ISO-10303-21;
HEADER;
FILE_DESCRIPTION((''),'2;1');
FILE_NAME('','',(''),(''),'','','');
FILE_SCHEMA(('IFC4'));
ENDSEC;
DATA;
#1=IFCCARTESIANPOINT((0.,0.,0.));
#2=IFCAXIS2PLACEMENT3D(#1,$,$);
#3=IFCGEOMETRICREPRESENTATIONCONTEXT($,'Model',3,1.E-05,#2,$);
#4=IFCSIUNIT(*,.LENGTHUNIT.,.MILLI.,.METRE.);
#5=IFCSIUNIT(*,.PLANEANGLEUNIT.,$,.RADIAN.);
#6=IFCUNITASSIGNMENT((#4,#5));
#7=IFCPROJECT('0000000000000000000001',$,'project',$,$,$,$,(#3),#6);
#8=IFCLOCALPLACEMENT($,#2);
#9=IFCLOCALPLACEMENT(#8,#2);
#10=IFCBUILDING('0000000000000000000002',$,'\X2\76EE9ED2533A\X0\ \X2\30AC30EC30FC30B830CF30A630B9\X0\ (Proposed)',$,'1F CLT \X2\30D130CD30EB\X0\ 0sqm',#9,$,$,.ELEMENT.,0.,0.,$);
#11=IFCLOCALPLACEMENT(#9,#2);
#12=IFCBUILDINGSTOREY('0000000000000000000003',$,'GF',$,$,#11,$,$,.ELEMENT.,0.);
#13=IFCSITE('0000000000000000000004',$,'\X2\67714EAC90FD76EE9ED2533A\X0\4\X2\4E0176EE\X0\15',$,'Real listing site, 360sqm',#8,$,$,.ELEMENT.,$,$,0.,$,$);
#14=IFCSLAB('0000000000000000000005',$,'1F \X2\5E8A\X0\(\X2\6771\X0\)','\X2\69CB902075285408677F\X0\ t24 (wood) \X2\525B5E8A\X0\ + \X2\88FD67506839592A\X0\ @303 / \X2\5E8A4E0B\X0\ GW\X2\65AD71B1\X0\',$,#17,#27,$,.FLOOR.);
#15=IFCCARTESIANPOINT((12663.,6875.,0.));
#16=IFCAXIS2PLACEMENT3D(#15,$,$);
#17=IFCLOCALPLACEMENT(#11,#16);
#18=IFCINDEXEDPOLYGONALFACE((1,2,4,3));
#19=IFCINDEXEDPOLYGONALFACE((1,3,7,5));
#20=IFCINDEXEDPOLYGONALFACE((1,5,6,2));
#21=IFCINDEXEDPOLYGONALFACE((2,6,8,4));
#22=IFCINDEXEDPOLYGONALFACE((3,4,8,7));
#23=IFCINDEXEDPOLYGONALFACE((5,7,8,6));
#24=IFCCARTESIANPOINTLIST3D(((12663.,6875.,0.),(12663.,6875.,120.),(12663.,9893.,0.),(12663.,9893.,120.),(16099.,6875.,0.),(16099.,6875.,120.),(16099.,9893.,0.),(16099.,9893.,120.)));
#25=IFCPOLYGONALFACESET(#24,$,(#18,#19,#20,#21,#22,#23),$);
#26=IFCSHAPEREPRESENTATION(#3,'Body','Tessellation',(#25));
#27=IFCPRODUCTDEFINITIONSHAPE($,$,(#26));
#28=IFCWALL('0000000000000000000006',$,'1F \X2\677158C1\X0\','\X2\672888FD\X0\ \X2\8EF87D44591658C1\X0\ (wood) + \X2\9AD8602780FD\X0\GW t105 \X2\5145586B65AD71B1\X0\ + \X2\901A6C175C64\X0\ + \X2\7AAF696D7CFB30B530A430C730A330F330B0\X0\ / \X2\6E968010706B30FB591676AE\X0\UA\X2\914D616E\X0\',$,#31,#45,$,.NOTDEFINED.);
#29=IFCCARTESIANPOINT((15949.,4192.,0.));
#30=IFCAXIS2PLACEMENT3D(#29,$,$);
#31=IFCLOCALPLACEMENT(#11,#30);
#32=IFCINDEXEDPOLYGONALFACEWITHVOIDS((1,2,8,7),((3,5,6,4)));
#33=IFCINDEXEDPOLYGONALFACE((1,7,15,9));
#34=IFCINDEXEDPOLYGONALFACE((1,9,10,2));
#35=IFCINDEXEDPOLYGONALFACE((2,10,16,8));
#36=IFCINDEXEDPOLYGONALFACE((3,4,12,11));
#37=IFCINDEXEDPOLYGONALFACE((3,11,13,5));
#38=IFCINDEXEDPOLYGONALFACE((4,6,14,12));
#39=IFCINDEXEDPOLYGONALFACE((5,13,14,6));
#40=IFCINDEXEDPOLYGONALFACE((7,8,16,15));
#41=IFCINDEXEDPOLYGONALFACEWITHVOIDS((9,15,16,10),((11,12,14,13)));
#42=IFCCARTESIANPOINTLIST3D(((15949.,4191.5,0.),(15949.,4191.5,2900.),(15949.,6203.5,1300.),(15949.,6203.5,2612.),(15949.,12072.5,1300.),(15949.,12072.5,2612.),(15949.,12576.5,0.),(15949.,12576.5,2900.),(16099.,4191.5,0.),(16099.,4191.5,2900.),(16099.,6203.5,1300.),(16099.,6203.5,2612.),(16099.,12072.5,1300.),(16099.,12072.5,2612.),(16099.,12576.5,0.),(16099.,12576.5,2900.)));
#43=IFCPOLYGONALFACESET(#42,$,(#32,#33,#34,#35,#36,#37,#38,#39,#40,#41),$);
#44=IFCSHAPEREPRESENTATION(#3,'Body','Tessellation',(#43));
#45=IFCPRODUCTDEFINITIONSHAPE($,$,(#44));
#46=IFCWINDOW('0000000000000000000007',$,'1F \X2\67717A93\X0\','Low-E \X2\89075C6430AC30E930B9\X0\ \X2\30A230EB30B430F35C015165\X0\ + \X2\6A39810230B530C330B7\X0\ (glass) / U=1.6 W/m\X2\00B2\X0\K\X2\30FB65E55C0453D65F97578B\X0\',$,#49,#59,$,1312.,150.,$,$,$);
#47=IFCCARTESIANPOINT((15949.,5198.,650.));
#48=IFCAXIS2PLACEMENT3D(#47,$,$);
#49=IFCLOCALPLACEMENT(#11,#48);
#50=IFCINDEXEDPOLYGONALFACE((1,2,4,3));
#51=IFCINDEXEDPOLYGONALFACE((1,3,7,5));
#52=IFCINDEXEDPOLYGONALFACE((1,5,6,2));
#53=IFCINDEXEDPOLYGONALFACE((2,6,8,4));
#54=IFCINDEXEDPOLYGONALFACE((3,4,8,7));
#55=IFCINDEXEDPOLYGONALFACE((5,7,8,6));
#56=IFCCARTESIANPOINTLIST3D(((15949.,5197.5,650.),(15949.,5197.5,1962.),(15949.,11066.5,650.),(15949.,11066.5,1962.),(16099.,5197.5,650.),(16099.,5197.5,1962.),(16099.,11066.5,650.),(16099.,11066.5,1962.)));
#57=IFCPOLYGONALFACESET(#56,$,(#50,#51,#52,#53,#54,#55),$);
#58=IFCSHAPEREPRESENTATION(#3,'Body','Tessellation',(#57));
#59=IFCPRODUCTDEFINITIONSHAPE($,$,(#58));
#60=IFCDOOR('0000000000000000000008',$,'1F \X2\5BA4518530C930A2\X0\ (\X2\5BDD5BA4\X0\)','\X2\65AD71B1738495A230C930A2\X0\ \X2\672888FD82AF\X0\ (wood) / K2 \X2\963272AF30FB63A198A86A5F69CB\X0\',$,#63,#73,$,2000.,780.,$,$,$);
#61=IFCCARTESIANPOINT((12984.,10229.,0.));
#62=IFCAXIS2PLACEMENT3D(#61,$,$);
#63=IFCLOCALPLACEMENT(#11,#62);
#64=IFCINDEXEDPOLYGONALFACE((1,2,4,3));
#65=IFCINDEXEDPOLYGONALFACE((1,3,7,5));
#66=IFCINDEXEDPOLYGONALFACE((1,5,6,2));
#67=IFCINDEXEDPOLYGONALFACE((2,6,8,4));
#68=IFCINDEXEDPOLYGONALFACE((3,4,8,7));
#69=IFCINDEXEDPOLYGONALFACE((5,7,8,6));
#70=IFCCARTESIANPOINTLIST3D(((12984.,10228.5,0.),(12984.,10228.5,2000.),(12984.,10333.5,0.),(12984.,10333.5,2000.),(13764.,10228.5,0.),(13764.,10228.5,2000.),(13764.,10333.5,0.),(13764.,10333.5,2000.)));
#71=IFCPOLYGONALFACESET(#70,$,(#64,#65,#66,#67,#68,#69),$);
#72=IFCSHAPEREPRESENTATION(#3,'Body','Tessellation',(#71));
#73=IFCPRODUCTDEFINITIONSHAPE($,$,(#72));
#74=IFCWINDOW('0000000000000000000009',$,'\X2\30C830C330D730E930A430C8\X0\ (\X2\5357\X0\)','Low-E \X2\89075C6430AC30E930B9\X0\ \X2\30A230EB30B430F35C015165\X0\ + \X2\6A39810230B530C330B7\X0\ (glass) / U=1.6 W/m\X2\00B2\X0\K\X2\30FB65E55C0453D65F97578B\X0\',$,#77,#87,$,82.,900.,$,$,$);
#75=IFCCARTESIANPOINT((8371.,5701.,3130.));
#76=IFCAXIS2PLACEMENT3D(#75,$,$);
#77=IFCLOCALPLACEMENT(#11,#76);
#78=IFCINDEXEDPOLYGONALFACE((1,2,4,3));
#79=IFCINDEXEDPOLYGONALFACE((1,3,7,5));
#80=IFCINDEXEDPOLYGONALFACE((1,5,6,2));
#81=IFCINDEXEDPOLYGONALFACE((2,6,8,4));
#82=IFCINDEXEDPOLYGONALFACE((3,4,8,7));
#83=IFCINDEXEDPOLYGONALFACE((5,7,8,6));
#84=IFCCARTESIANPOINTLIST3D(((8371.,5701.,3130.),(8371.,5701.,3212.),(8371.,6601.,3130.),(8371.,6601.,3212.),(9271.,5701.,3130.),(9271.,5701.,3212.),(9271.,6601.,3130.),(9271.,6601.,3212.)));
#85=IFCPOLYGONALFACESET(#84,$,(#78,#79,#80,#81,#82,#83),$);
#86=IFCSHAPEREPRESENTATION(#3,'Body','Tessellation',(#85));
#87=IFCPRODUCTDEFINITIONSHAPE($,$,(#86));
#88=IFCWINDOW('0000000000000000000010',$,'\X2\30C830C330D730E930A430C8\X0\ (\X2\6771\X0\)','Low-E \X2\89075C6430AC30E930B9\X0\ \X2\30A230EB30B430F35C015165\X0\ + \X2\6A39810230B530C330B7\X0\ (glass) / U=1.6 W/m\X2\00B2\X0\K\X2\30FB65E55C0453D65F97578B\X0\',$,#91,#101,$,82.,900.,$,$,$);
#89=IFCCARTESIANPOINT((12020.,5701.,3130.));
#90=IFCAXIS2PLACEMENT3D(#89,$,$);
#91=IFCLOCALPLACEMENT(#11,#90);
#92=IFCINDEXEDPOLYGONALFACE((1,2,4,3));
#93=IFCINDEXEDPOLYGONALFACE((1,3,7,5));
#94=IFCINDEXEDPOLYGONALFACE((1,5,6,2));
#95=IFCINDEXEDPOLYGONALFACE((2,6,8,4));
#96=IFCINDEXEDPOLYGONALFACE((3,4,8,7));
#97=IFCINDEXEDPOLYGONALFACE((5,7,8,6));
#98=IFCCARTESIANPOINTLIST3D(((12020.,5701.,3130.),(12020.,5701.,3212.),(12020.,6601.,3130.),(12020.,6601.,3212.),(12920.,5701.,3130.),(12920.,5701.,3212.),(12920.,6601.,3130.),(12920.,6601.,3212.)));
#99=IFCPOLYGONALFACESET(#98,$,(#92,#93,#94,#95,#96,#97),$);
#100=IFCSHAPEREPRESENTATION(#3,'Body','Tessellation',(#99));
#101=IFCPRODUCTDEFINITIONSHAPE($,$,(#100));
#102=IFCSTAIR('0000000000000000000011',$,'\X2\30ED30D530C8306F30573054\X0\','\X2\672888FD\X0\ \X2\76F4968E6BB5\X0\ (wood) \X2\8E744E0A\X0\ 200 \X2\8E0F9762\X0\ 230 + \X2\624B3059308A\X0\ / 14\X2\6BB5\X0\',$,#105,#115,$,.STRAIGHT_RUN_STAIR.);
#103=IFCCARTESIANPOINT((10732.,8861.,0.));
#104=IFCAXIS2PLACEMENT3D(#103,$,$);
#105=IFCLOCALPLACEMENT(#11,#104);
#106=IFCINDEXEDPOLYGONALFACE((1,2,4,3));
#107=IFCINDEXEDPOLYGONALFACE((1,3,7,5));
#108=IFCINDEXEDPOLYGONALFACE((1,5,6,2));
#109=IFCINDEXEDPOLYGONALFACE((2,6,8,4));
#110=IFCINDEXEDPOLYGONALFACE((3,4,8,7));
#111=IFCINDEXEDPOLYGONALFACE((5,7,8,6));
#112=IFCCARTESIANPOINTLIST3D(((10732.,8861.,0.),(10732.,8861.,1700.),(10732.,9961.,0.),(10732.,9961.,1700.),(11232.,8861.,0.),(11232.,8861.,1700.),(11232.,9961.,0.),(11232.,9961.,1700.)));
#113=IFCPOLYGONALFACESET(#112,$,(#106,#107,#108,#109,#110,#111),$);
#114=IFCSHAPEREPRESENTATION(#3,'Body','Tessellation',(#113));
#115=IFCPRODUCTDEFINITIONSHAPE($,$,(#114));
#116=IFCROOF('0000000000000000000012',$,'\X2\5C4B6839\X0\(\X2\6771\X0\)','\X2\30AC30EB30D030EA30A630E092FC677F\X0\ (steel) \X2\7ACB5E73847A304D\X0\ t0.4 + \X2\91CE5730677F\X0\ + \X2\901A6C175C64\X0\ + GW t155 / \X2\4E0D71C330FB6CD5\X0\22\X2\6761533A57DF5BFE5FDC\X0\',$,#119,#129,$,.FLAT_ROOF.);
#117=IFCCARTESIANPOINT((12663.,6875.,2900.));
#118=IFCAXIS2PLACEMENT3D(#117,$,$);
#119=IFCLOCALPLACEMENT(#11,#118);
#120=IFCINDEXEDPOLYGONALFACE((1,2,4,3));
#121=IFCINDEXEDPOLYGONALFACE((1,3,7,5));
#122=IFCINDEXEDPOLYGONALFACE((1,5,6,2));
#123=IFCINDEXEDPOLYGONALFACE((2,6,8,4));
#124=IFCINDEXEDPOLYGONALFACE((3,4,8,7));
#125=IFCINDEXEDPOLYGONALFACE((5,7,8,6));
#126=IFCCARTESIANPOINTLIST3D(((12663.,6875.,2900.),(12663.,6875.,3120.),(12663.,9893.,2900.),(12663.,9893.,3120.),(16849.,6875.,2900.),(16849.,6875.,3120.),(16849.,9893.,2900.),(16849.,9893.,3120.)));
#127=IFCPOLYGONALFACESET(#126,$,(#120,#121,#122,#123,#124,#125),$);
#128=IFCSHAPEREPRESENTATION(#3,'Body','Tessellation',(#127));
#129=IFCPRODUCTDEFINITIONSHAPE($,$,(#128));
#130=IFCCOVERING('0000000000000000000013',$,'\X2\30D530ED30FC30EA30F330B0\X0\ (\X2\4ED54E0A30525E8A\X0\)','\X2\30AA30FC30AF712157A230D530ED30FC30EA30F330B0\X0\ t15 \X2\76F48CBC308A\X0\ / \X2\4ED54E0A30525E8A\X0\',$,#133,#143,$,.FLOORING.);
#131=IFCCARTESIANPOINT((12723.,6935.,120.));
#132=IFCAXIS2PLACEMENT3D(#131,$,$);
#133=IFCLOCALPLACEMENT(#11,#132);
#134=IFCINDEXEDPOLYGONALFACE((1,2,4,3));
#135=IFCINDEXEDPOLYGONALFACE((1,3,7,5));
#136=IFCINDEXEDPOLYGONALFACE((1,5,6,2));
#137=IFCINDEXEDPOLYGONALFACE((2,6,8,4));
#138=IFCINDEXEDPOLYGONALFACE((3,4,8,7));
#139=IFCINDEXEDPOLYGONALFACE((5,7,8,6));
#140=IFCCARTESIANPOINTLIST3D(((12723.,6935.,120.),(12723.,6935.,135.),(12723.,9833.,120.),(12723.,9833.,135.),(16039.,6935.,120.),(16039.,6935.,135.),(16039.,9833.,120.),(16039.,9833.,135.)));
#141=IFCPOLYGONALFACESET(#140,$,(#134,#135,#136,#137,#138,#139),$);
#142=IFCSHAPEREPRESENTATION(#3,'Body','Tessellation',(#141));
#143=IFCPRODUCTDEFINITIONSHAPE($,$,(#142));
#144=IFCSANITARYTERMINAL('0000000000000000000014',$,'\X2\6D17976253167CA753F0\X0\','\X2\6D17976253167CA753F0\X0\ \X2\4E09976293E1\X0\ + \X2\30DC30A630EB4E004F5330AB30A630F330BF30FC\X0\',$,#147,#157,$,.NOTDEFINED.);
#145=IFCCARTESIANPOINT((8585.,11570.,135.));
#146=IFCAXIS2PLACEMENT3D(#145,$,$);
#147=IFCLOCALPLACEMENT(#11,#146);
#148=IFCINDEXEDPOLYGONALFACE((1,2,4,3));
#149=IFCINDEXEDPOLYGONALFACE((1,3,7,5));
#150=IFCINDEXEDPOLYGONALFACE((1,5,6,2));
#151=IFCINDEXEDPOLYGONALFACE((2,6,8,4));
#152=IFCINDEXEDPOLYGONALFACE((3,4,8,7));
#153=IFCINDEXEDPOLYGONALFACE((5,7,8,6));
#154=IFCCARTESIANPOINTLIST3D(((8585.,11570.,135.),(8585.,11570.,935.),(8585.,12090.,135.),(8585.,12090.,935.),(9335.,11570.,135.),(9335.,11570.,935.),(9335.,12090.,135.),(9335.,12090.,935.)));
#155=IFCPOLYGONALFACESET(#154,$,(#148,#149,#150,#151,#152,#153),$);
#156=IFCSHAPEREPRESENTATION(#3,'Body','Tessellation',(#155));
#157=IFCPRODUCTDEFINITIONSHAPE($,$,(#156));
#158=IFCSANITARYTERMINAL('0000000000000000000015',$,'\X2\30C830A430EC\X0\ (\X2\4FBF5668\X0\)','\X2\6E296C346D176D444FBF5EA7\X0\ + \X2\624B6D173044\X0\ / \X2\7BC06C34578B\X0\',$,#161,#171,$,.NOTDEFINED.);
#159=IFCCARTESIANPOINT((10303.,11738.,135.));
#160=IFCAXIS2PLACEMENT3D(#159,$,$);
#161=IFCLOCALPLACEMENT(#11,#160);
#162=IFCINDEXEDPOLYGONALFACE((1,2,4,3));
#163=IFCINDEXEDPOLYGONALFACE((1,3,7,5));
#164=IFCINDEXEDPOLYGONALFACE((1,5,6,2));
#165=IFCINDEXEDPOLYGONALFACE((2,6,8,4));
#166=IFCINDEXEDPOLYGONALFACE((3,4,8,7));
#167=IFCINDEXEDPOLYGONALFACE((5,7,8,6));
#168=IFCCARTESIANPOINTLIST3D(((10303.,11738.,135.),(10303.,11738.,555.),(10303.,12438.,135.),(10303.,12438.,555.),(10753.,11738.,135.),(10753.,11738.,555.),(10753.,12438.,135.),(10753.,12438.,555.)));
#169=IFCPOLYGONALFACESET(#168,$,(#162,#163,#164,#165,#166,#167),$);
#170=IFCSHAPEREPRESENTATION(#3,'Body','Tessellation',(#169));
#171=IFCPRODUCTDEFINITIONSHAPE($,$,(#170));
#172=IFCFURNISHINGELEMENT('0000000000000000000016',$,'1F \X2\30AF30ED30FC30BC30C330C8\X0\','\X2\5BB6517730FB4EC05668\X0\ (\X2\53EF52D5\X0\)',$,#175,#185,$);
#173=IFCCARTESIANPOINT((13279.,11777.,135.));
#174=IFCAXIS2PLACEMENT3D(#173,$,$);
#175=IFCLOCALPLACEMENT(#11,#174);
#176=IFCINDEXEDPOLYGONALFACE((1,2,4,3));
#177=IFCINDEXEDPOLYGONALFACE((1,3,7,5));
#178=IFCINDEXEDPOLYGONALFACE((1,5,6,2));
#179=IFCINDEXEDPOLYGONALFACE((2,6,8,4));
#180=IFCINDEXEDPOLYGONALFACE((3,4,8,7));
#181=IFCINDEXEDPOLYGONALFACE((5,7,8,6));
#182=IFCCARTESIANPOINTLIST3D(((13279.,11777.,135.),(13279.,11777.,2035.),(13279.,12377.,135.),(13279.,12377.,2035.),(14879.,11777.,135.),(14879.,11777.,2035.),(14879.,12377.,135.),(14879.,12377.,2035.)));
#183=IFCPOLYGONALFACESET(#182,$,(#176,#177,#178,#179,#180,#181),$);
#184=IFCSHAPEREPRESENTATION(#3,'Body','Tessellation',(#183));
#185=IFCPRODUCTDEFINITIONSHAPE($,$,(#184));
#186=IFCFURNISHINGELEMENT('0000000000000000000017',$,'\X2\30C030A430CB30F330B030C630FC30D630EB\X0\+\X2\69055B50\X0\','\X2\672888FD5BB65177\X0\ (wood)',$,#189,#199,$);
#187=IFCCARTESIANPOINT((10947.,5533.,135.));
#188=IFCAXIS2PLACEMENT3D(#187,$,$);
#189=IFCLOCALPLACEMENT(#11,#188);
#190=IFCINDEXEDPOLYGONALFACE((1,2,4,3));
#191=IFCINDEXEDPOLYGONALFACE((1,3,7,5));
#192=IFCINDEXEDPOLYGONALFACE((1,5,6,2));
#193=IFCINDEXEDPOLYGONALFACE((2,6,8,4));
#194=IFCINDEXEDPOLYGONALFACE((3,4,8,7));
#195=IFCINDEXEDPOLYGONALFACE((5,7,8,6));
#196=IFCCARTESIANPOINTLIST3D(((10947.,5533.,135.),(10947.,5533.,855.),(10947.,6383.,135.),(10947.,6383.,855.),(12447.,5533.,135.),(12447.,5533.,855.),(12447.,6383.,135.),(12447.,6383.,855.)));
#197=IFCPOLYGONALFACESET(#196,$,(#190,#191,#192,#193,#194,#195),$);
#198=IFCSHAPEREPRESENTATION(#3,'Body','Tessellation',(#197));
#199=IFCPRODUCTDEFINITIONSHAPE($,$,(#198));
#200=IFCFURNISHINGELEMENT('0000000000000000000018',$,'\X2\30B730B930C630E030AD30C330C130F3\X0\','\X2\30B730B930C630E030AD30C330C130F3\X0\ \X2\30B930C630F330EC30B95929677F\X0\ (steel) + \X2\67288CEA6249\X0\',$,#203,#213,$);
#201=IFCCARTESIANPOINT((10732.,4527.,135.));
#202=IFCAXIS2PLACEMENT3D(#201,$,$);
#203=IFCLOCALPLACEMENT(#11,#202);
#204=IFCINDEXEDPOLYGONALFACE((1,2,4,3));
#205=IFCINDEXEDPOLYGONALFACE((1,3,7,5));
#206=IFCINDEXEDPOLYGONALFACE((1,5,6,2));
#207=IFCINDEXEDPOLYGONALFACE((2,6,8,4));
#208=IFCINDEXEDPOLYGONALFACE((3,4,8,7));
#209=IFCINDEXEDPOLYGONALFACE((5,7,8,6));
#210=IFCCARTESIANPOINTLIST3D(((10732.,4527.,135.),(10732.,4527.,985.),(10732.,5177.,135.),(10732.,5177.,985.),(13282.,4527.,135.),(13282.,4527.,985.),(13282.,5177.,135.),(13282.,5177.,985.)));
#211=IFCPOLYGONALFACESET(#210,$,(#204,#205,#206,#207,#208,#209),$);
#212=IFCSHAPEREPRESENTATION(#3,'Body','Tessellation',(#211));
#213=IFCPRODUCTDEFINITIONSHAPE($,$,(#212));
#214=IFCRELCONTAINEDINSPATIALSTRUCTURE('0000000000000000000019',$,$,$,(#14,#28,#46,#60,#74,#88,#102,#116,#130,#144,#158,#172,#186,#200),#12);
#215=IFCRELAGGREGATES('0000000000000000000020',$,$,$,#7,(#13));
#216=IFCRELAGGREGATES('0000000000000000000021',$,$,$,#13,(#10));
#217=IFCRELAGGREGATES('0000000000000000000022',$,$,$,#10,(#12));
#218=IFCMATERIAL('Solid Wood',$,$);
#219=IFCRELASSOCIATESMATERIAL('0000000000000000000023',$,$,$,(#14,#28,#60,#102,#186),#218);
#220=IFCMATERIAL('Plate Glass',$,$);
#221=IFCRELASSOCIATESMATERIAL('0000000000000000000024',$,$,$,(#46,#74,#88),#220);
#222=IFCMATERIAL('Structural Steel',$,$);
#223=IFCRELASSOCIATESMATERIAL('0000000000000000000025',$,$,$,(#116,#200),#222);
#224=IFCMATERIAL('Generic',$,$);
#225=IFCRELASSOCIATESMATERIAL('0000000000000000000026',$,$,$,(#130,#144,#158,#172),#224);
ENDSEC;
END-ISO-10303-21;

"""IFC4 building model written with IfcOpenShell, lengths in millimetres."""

from ifc_helpers import new_model, si_unit, frame, frame_2d, origin, place, context, project, spatial, rectangle, extrude, material, element, fill, save


model = new_model("IFC4")

# Units and contexts
model_context = context("Model", 3, precision=1e-05, world=origin())
ifc_project = project(units=[si_unit("LENGTHUNIT", "METRE", prefix="MILLI"), si_unit("PLANEANGLEUNIT", "RADIAN")], contexts=[model_context])

# Site, building, storey
site_placement = place(None, origin())
site = spatial("IfcSite", under=ifc_project, at=site_placement, Name="東京都目黒区4丁目15", ObjectType="Real listing site, 360sqm", CompositionType="ELEMENT", RefElevation=0.0)
building_placement = place(site_placement, origin())
building = spatial("IfcBuilding", under=site, at=building_placement, Name="目黒区 ガレージハウス (Proposed)", ObjectType="1F CLT パネル 0sqm", CompositionType="ELEMENT", ElevationOfRefHeight=0.0, ElevationOfTerrain=0.0)
storey_placement = place(building_placement, origin())
storey = spatial("IfcBuildingStorey", under=building, at=storey_placement, Name="GF", CompositionType="ELEMENT", Elevation=0.0)

# Slab
ifc_material_1 = material(Name="Solid Wood")
slab_1_placement = place(storey_placement, frame((12663.0, 6875.0, 0.0)))
element("IfcSlab", 1, at=slab_1_placement, inside=storey, material=ifc_material_1, Name="1F 床(東)", Description="構造用合板 t24 (wood) 剛床 + 製材根太 @303 / 床下 GW断熱", PredefinedType="FLOOR", context=model_context, shape_type="SweptSolid", body=[
    extrude(rectangle(XDim=3436.0, YDim=3018.0, at=frame_2d((1718.0, 1509.0))), frame((12663.0, 6875.0, 0.0)), (0.0, 0.0, 1.0), 120.0),
])

# Wall, opening, window
wall_1_placement = place(storey_placement, frame((15949.0, 4192.0, 0.0)))
wall_1 = element("IfcWall", 2, at=wall_1_placement, inside=storey, material=ifc_material_1, Name="1F 東壁", Description="木製 軸組外壁 (wood) + 高性能GW t105 充填断熱 + 通気層 + 窯業系サイディング / 準耐火・外皮UA配慮", PredefinedType="NOTDEFINED", context=model_context, shape_type="SweptSolid", body=[
    extrude(rectangle(XDim=150.0, YDim=8385.0, at=frame_2d((75.0, 4192.0))), frame((15949.0, 4192.0, 0.0)), (0.0, 0.0, 1.0), 2900.0),
])
opening_1_placement = place(storey_placement, frame((15949.0, 5198.0, 650.0)))
opening_1 = element("IfcOpeningElement", 3, at=opening_1_placement, cuts=wall_1, PredefinedType="NOTDEFINED", context=model_context, shape_type="SweptSolid", body=[
    extrude(rectangle(XDim=150.0, YDim=5869.0, at=frame_2d((75.0, 2934.0))), frame((15949.0, 5198.0, 650.0)), (0.0, 0.0, 1.0), 1312.0),
])
ifc_material_2 = material(Name="Plate Glass")
window_1_placement = place(storey_placement, frame((15949.0, 5198.0, 650.0)))
window_1 = element("IfcWindow", 4, at=window_1_placement, inside=storey, material=ifc_material_2, Name="1F 東窓", Description="Low-E 複層ガラス アルゴン封入 + 樹脂サッシ (glass) / U=1.6 W/m²K・日射取得型", OverallHeight=1312.0, OverallWidth=150.0, context=model_context, shape_type="SweptSolid", body=[
    extrude(rectangle(XDim=150.0, YDim=5869.0, at=frame_2d((75.0, 2934.0))), frame((15949.0, 5198.0, 650.0)), (0.0, 0.0, 1.0), 1312.0),
])
fill(opening_1, window_1)

# Door
door_placement = place(storey_placement, frame((12984.0, 10229.0, 0.0)))
element("IfcDoor", 5, at=door_placement, inside=storey, material=ifc_material_1, Name="1F 室内ドア (寝室)", Description="断熱玄関ドア 木製芯 (wood) / K2 防犯・採風機構", OverallHeight=2000.0, OverallWidth=780.0, context=model_context, shape_type="SweptSolid", body=[
    extrude(rectangle(XDim=780.0, YDim=105.0, at=frame_2d((390.0, 52.0))), frame((12984.0, 10229.0, 0.0)), (0.0, 0.0, 1.0), 2000.0),
])

# Windows
window_2_placement = place(storey_placement, frame((8371.0, 5701.0, 3130.0)))
element("IfcWindow", 6, at=window_2_placement, inside=storey, material=ifc_material_2, Name="トップライト (南)", Description="Low-E 複層ガラス アルゴン封入 + 樹脂サッシ (glass) / U=1.6 W/m²K・日射取得型", OverallHeight=82.0, OverallWidth=900.0, context=model_context, shape_type="SweptSolid", body=[
    extrude(rectangle(XDim=900.0, YDim=900.0, at=frame_2d((450.0, 450.0))), frame((8371.0, 5701.0, 3130.0)), (0.0, 0.0, 1.0), 82.0),
])
window_3_placement = place(storey_placement, frame((12020.0, 5701.0, 3130.0)))
element("IfcWindow", 7, at=window_3_placement, inside=storey, material=ifc_material_2, Name="トップライト (東)", Description="Low-E 複層ガラス アルゴン封入 + 樹脂サッシ (glass) / U=1.6 W/m²K・日射取得型", OverallHeight=82.0, OverallWidth=900.0, context=model_context, shape_type="SweptSolid", body=[
    extrude(rectangle(XDim=900.0, YDim=900.0, at=frame_2d((450.0, 450.0))), frame((12020.0, 5701.0, 3130.0)), (0.0, 0.0, 1.0), 82.0),
])

# Stair
stair_placement = place(storey_placement, frame((10732.0, 8861.0, 0.0)))
element("IfcStair", 8, at=stair_placement, inside=storey, material=ifc_material_1, Name="ロフトはしご", Description="木製 直階段 (wood) 蹴上 200 踏面 230 + 手すり / 14段", PredefinedType="STRAIGHT_RUN_STAIR", context=model_context, shape_type="SweptSolid", body=[
    extrude(rectangle(XDim=500.0, YDim=1100.0, at=frame_2d((250.0, 550.0))), frame((10732.0, 8861.0, 0.0)), (0.0, 0.0, 1.0), 1700.0),
])

# Roof
ifc_material_3 = material(Name="Structural Steel")
roof_placement = place(storey_placement, frame((12663.0, 6875.0, 2900.0)))
element("IfcRoof", 9, at=roof_placement, inside=storey, material=ifc_material_3, Name="屋根(東)", Description="ガルバリウム鋼板 (steel) 立平葺き t0.4 + 野地板 + 通気層 + GW t155 / 不燃・法22条区域対応", PredefinedType="FLAT_ROOF", context=model_context, shape_type="SweptSolid", body=[
    extrude(rectangle(XDim=4186.0, YDim=3018.0, at=frame_2d((2093.0, 1509.0))), frame((12663.0, 6875.0, 2900.0)), (0.0, 0.0, 1.0), 220.0),
])

# Covering
ifc_material_4 = material(Name="Generic")
covering_placement = place(storey_placement, frame((12723.0, 6935.0, 120.0)))
element("IfcCovering", 10, at=covering_placement, inside=storey, material=ifc_material_4, Name="フローリング (仕上げ床)", Description="オーク無垢フローリング t15 直貼り / 仕上げ床", PredefinedType="FLOORING", context=model_context, shape_type="SweptSolid", body=[
    extrude(rectangle(XDim=3316.0, YDim=2898.0, at=frame_2d((1658.0, 1449.0))), frame((12723.0, 6935.0, 120.0)), (0.0, 0.0, 1.0), 15.0),
])

# Sanitary terminals
sanitary_terminal_1_placement = place(storey_placement, frame((8585.0, 11570.0, 135.0)))
element("IfcSanitaryTerminal", 11, at=sanitary_terminal_1_placement, inside=storey, material=ifc_material_4, Name="洗面化粧台", Description="洗面化粧台 三面鏡 + ボウル一体カウンター", PredefinedType="NOTDEFINED", context=model_context, shape_type="SweptSolid", body=[
    extrude(rectangle(XDim=750.0, YDim=520.0, at=frame_2d((375.0, 260.0))), frame((8585.0, 11570.0, 135.0)), (0.0, 0.0, 1.0), 800.0),
])
sanitary_terminal_2_placement = place(storey_placement, frame((10303.0, 11738.0, 135.0)))
element("IfcSanitaryTerminal", 12, at=sanitary_terminal_2_placement, inside=storey, material=ifc_material_4, Name="トイレ (便器)", Description="温水洗浄便座 + 手洗い / 節水型", PredefinedType="NOTDEFINED", context=model_context, shape_type="SweptSolid", body=[
    extrude(rectangle(XDim=450.0, YDim=700.0, at=frame_2d((225.0, 350.0))), frame((10303.0, 11738.0, 135.0)), (0.0, 0.0, 1.0), 420.0),
])

# Furnishing elements
furnishing_1_placement = place(storey_placement, frame((13279.0, 11777.0, 135.0)))
element("IfcFurnishingElement", 13, at=furnishing_1_placement, inside=storey, material=ifc_material_4, Name="1F クローゼット", Description="家具・什器 (可動)", context=model_context, shape_type="SweptSolid", body=[
    extrude(rectangle(XDim=1600.0, YDim=600.0, at=frame_2d((800.0, 300.0))), frame((13279.0, 11777.0, 135.0)), (0.0, 0.0, 1.0), 1900.0),
])
furnishing_2_placement = place(storey_placement, frame((10947.0, 5533.0, 135.0)))
element("IfcFurnishingElement", 14, at=furnishing_2_placement, inside=storey, material=ifc_material_1, Name="ダイニングテーブル+椅子", Description="木製家具 (wood)", context=model_context, shape_type="SweptSolid", body=[
    extrude(rectangle(XDim=1500.0, YDim=850.0, at=frame_2d((750.0, 425.0))), frame((10947.0, 5533.0, 135.0)), (0.0, 0.0, 1.0), 720.0),
])
furnishing_3_placement = place(storey_placement, frame((10732.0, 4527.0, 135.0)))
element("IfcFurnishingElement", 15, at=furnishing_3_placement, inside=storey, material=ifc_material_3, Name="システムキッチン", Description="システムキッチン ステンレス天板 (steel) + 木質扉", context=model_context, shape_type="SweptSolid", body=[
    extrude(rectangle(XDim=2550.0, YDim=650.0, at=frame_2d((1275.0, 325.0))), frame((10732.0, 4527.0, 135.0)), (0.0, 0.0, 1.0), 850.0),
])

save(model, "model.ifc")
